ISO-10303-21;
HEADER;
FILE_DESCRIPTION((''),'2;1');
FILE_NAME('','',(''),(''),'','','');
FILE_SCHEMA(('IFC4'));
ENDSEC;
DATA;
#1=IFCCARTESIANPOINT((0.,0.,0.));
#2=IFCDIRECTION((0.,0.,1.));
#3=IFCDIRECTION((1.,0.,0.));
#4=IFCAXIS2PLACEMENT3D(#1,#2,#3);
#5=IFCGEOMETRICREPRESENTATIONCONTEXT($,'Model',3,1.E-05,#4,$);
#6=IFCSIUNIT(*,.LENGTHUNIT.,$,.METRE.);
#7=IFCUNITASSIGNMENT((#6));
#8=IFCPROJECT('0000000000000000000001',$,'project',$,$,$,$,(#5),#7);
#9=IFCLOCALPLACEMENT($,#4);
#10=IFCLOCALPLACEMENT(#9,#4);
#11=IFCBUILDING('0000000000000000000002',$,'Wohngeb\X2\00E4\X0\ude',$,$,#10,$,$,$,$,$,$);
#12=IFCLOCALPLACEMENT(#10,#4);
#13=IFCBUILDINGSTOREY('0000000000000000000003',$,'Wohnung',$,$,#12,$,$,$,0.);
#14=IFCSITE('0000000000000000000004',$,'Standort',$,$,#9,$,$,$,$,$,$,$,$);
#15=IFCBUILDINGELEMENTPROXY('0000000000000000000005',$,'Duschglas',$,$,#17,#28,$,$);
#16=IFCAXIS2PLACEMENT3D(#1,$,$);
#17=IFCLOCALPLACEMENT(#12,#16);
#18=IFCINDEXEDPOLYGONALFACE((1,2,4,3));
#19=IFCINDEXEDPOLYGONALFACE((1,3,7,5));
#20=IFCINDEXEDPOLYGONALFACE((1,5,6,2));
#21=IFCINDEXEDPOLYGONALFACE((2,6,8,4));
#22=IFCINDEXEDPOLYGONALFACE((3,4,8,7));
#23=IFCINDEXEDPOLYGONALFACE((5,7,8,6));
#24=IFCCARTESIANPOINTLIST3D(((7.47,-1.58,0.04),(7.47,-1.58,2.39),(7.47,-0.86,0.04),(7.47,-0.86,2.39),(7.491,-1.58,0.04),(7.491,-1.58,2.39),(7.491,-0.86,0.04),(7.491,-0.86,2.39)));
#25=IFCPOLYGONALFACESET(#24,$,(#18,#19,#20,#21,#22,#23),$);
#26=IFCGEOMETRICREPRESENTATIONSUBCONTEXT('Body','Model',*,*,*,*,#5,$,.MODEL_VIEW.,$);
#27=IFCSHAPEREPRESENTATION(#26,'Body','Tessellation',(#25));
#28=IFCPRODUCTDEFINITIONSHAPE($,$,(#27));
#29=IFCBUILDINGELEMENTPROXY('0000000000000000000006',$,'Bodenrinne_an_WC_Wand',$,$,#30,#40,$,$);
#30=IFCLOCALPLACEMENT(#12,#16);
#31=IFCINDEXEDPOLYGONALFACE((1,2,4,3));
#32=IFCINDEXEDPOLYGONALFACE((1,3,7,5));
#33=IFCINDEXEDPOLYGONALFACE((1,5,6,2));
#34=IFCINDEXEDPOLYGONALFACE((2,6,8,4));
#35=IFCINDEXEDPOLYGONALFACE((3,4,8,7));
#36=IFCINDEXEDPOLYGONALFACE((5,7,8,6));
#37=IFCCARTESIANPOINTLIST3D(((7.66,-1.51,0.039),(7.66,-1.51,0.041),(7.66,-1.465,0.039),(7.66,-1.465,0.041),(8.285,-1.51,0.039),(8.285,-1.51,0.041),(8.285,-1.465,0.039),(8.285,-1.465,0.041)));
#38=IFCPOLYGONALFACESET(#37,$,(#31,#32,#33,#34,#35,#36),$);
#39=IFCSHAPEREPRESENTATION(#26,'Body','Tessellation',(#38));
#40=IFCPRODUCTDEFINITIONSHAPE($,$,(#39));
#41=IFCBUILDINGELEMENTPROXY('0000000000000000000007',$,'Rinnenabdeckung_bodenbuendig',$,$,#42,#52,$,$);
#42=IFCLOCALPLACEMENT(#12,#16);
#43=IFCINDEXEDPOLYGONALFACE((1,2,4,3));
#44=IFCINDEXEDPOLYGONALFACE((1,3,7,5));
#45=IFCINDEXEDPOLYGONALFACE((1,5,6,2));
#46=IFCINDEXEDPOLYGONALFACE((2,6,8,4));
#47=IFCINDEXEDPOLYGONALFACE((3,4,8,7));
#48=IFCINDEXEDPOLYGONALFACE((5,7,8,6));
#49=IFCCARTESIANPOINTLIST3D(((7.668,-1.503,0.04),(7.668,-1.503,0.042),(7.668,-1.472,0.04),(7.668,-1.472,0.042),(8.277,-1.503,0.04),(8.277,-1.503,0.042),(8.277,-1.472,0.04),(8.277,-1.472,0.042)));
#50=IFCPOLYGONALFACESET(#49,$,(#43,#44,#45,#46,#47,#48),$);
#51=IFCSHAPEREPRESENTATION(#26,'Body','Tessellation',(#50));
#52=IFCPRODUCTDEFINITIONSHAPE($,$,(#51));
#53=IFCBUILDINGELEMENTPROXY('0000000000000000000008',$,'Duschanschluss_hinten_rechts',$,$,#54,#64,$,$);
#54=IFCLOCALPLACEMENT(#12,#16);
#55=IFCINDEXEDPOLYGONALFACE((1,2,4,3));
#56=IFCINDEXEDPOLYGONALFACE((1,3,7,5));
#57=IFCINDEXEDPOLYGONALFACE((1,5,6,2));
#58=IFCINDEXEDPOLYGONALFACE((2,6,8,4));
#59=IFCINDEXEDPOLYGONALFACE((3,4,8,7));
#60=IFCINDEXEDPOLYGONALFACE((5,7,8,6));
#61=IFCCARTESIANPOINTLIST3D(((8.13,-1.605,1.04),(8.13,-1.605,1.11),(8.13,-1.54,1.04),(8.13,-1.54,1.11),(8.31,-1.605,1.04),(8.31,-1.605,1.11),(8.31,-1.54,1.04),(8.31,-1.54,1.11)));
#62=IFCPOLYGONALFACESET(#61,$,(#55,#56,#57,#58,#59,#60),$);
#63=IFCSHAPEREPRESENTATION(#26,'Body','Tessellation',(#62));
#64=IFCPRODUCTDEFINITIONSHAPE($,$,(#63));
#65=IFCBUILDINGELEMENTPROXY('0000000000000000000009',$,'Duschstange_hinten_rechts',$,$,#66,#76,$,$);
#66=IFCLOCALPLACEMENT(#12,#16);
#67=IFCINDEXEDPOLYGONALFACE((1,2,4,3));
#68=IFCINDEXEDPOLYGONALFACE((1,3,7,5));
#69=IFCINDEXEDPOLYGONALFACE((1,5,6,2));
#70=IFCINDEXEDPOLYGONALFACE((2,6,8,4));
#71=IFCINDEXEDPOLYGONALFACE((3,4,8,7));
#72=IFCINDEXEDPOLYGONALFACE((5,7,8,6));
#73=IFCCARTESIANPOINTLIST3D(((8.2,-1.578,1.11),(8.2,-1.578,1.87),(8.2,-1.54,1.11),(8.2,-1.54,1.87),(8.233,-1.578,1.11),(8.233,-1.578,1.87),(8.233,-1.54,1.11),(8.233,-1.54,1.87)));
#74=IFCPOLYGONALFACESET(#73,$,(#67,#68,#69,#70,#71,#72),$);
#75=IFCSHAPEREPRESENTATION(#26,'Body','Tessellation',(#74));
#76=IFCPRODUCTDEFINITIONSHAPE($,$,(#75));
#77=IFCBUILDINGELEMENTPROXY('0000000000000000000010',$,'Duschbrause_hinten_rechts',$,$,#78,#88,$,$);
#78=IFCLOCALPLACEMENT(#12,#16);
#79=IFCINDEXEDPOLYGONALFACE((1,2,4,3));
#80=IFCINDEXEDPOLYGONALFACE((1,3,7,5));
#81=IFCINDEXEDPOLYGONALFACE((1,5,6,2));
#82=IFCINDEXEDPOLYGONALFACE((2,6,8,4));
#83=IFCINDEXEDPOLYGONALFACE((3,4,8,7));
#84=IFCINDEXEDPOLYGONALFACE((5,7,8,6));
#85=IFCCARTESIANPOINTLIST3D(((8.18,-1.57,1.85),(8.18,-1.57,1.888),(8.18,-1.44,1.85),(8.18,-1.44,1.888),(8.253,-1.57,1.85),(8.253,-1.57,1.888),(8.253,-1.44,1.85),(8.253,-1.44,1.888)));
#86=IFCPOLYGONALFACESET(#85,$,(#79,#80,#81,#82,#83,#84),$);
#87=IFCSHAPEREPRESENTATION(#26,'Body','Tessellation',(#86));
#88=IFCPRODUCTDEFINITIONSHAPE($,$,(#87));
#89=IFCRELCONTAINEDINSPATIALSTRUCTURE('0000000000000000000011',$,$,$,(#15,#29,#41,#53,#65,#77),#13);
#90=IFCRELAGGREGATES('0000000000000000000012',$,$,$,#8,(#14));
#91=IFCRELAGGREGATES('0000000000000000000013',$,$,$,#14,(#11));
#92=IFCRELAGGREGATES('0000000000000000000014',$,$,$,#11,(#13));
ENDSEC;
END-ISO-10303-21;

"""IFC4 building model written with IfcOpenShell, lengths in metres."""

from ifc_helpers import new_model, si_unit, frame, origin, origin_with_axes, place, context, subcontext, project, spatial, polyline, outline, extrude, element, save


model = new_model("IFC4")

# Units and contexts
model_context = context("Model", 3, precision=1e-05, world=origin_with_axes())
body_context = subcontext(model_context, "Body", "Model", "MODEL_VIEW")
ifc_project = project(units=[si_unit("LENGTHUNIT", "METRE")], contexts=[model_context])

# Site, building, storey
site_placement = place(None, origin_with_axes())
site = spatial("IfcSite", under=ifc_project, at=site_placement, Name="Standort")
building_placement = place(site_placement, origin_with_axes())
building = spatial("IfcBuilding", under=site, at=building_placement, Name="Wohngebäude")
storey_placement = place(building_placement, origin_with_axes())
storey = spatial("IfcBuildingStorey", under=building, at=storey_placement, Name="Wohnung", Elevation=0.0)

# Building element proxies
proxy_1_placement = place(storey_placement, frame((7.47, -0.86, 0.04), z_axis=(0.0, 0.0, 1.0), x_axis=(1.0, 0.0, 0.0)))
element("IfcBuildingElementProxy", 1, at=proxy_1_placement, inside=storey, Name="Duschglas", context=body_context, shape_type="SweptSolid", body=[
    extrude(outline(polyline([(0.0, 0.0), (0.0, -0.72), (0.021, -0.72), (0.021, 0.0), (0.0, 0.0)])), origin(), (0.0, 0.0, 1.0), 2.35),
])
proxy_2_placement = place(storey_placement, frame((7.66, -1.465, 0.039), z_axis=(0.0, 0.0, 1.0), x_axis=(1.0, 0.0, 0.0)))
element("IfcBuildingElementProxy", 2, at=proxy_2_placement, inside=storey, Name="Bodenrinne_an_WC_Wand", context=body_context, shape_type="SweptSolid", body=[
    extrude(outline(polyline([(0.0, 0.0), (0.0, -0.045), (0.625, -0.045), (0.625, 0.0), (0.0, 0.0)])), origin(), (0.0, 0.0, 1.0), 0.002),
])
proxy_3_placement = place(storey_placement, frame((7.668, -1.472, 0.04), z_axis=(0.0, 0.0, 1.0), x_axis=(1.0, 0.0, 0.0)))
element("IfcBuildingElementProxy", 3, at=proxy_3_placement, inside=storey, Name="Rinnenabdeckung_bodenbuendig", context=body_context, shape_type="SweptSolid", body=[
    extrude(outline(polyline([(0.0, 0.0), (0.0, -0.031), (0.609, -0.031), (0.609, 0.0), (0.0, 0.0)])), origin(), (0.0, 0.0, 1.0), 0.002),
])
proxy_4_placement = place(storey_placement, frame((8.13, -1.54, 1.04), z_axis=(0.0, 0.0, 1.0), x_axis=(1.0, 0.0, 0.0)))
element("IfcBuildingElementProxy", 4, at=proxy_4_placement, inside=storey, Name="Duschanschluss_hinten_rechts", context=body_context, shape_type="SweptSolid", body=[
    extrude(outline(polyline([(0.0, 0.0), (0.0, -0.065), (0.18, -0.065), (0.18, 0.0), (0.0, 0.0)])), origin(), (0.0, 0.0, 1.0), 0.07),
])
proxy_5_placement = place(storey_placement, frame((8.2, -1.54, 1.11), z_axis=(0.0, 0.0, 1.0), x_axis=(1.0, 0.0, 0.0)))
element("IfcBuildingElementProxy", 5, at=proxy_5_placement, inside=storey, Name="Duschstange_hinten_rechts", context=body_context, shape_type="SweptSolid", body=[
    extrude(outline(polyline([(0.0, 0.0), (0.0, -0.038), (0.033, -0.038), (0.033, 0.0), (0.0, 0.0)])), origin(), (0.0, 0.0, 1.0), 0.76),
])
proxy_6_placement = place(storey_placement, frame((8.18, -1.44, 1.85), z_axis=(0.0, 0.0, 1.0), x_axis=(1.0, 0.0, 0.0)))
element("IfcBuildingElementProxy", 6, at=proxy_6_placement, inside=storey, Name="Duschbrause_hinten_rechts", context=body_context, shape_type="SweptSolid", body=[
    extrude(outline(polyline([(0.0, 0.0), (0.0, -0.13), (0.073, -0.13), (0.073, 0.0), (0.0, 0.0)])), origin(), (0.0, 0.0, 1.0), 0.038),
])

save(model, "model.ifc")
